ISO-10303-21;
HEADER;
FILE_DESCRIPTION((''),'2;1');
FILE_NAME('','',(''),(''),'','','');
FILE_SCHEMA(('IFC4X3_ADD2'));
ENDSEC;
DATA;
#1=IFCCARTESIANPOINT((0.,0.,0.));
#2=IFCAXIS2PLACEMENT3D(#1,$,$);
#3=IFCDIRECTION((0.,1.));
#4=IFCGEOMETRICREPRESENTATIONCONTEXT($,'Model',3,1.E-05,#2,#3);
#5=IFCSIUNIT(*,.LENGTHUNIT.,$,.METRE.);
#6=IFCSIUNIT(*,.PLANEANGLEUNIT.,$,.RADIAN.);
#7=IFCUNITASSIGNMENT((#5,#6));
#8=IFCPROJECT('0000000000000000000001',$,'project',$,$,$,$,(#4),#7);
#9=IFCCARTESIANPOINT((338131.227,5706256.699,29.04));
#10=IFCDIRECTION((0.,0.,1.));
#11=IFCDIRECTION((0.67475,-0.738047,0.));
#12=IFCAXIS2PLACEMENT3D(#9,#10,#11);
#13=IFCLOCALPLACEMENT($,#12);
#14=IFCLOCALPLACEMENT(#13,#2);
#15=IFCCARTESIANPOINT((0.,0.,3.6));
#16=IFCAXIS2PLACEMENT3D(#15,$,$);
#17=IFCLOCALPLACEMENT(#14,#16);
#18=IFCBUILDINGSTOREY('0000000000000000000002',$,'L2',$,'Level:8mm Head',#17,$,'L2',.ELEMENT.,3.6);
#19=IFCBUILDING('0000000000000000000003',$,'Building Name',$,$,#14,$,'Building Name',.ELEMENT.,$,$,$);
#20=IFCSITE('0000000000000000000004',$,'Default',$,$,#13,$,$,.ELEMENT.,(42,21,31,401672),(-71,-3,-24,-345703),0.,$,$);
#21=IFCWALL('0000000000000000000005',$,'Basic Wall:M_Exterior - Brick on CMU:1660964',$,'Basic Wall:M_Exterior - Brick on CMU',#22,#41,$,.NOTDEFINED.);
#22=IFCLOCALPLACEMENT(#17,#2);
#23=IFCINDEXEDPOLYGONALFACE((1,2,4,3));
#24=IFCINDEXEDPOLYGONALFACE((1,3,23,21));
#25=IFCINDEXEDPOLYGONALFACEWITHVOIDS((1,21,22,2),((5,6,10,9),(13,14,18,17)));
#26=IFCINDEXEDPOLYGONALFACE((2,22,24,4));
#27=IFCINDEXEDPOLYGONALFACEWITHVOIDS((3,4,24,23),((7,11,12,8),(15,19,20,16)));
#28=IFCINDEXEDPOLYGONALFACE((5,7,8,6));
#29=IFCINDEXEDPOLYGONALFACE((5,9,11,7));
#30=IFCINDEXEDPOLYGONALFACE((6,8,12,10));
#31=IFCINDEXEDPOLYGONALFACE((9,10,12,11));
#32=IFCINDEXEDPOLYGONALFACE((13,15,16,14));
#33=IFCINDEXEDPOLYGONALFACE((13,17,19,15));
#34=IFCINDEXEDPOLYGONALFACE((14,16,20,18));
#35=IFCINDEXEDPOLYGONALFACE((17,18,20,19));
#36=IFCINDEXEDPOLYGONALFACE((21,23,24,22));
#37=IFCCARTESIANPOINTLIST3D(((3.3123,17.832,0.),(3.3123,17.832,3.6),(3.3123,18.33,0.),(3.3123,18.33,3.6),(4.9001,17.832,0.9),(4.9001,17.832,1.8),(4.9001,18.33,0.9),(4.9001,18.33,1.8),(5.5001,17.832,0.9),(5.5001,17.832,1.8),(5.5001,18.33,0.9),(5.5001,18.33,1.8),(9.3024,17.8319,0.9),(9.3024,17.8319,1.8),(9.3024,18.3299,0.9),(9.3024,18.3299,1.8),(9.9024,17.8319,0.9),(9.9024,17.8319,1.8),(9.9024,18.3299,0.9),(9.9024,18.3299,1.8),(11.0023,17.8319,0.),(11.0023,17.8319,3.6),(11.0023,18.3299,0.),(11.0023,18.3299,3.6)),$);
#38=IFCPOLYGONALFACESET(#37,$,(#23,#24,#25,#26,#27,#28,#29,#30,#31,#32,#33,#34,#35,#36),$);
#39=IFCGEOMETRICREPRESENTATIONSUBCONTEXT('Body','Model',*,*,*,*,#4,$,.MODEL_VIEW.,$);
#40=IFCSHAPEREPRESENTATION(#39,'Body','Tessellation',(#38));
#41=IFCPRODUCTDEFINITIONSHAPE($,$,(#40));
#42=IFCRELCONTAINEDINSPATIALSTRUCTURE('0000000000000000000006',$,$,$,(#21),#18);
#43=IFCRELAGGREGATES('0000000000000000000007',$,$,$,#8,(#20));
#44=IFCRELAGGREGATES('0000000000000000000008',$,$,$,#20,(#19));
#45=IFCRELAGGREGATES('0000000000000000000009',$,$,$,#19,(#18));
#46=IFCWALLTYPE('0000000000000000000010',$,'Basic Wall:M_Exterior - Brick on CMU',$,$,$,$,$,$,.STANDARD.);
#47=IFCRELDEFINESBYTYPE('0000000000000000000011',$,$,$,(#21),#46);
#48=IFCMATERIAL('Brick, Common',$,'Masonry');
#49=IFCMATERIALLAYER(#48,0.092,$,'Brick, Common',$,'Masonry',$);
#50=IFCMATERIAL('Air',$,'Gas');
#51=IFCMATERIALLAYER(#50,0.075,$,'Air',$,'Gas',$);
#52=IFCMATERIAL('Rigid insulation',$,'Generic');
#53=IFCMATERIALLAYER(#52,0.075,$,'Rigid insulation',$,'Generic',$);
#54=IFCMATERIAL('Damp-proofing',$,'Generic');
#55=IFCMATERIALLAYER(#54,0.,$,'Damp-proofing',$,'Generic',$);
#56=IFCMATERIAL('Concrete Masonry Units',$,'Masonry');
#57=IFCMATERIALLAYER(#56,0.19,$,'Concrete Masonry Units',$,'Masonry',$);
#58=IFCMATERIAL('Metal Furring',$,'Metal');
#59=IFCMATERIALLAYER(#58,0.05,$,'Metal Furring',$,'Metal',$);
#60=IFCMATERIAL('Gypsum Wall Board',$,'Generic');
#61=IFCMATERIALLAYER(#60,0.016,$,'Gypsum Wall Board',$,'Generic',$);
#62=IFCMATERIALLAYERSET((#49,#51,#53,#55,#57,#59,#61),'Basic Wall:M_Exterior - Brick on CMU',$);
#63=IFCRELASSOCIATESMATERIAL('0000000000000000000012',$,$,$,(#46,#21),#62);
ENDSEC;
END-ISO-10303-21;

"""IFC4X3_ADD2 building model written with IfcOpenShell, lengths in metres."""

from ifc_helpers import new_model, si_unit, direction, frame, frame_2d, origin, place, context, subcontext, project, spatial, rectangle, extrude, material, layer, layer_set, type_object, element, save


model = new_model("IFC4X3_ADD2")

# Units and contexts
model_context = context("Model", 3, precision=1e-05, world=origin(), true_north=direction((0.0, 1.0)))
body_context = subcontext(model_context, "Body", "Model", "MODEL_VIEW")
ifc_project = project(units=[si_unit("LENGTHUNIT", "METRE"), si_unit("PLANEANGLEUNIT", "RADIAN")], contexts=[model_context])

# Site, building, storey
site_placement = place(None, frame((338131.227, 5706256.699, 29.04), z_axis=(0.0, 0.0, 1.0), x_axis=(0.67475, -0.738047, 0.0)))
site = spatial("IfcSite", under=ifc_project, at=site_placement, Name="Default", CompositionType="ELEMENT", RefLatitude=(42, 21, 31, 401672), RefLongitude=(-71, -3, -24, -345703), RefElevation=0.0)
building_placement = place(site_placement, origin())
building = spatial("IfcBuilding", under=site, at=building_placement, Name="Building Name", LongName="Building Name", CompositionType="ELEMENT")
storey_placement = place(building_placement, frame((0.0, 0.0, 3.6)))
storey = spatial("IfcBuildingStorey", under=building, at=storey_placement, Name="L2", ObjectType="Level:8mm Head", LongName="L2", CompositionType="ELEMENT", Elevation=3.6)

# Shared definitions
ifc_material_1 = material(Name="Brick, Common", Category="Masonry")
ifc_layer_1 = layer(ifc_material_1, 0.092, Name="Brick, Common", Category="Masonry")
ifc_material_2 = material(Name="Air", Category="Gas")
ifc_layer_2 = layer(ifc_material_2, 0.075, Name="Air", Category="Gas")
ifc_material_3 = material(Name="Rigid insulation", Category="Generic")
ifc_layer_3 = layer(ifc_material_3, 0.075, Name="Rigid insulation", Category="Generic")
ifc_material_4 = material(Name="Damp-proofing", Category="Generic")
ifc_layer_4 = layer(ifc_material_4, 0.0, Name="Damp-proofing", Category="Generic")
ifc_material_5 = material(Name="Concrete Masonry Units", Category="Masonry")
ifc_layer_5 = layer(ifc_material_5, 0.19, Name="Concrete Masonry Units", Category="Masonry")
ifc_material_6 = material(Name="Metal Furring", Category="Metal")
ifc_layer_6 = layer(ifc_material_6, 0.05, Name="Metal Furring", Category="Metal")
ifc_material_7 = material(Name="Gypsum Wall Board", Category="Generic")
ifc_layer_7 = layer(ifc_material_7, 0.016, Name="Gypsum Wall Board", Category="Generic")
ifc_layer_set = layer_set([ifc_layer_1, ifc_layer_2, ifc_layer_3, ifc_layer_4, ifc_layer_5, ifc_layer_6, ifc_layer_7], Name="Basic Wall:M_Exterior - Brick on CMU")
wall_type = type_object("IfcWallType", Name="Basic Wall:M_Exterior - Brick on CMU", PredefinedType="STANDARD", material=ifc_layer_set)

# Wall, openings
wall_1_placement = place(storey_placement, frame((11.0023, 18.0809, 0.0), z_axis=(0.0, 0.0, 1.0), x_axis=(-1.0, 0.000006, 0.0)))
wall_1 = element("IfcWall", 1, at=wall_1_placement, inside=storey, type_object=wall_type, material=ifc_layer_set, Name="Basic Wall:M_Exterior - Brick on CMU:1660964", ObjectType="Basic Wall:M_Exterior - Brick on CMU", PredefinedType="NOTDEFINED", context=body_context, shape_type="SweptSolid", body=[
    extrude(rectangle(XDim=7.69, YDim=0.498, at=frame_2d((3.845, 0.0), x_axis=(-1.0, 0.0))), origin(), (0.0, 0.0, 1.0), 3.6),
])
opening_1_placement = place(wall_1_placement, frame((11.0021, 18.0811, 0.9)))
element("IfcOpeningElement", 2, at=opening_1_placement, cuts=wall_1, PredefinedType="OPENING", context=body_context, shape_type="SweptSolid", body=[
    extrude(rectangle(XDim=0.9, YDim=0.6, at=frame_2d((0.0, 0.0), x_axis=(0.0, 1.0))), frame((-5.1999, -19.356, 0.45), z_axis=(0.0, 1.0, 0.0), x_axis=(1.0, 0.0, 0.0)), (0.0, 0.0, 1.0), 3.048),
])
opening_2_placement = place(wall_1_placement, frame((11.0021, 18.0811, 0.9)))
element("IfcOpeningElement", 3, at=opening_2_placement, cuts=wall_1, PredefinedType="OPENING", context=body_context, shape_type="SweptSolid", body=[
    extrude(rectangle(XDim=0.9, YDim=0.6, at=frame_2d((0.0, 0.0), x_axis=(0.0, 1.0))), frame((-9.6022, -19.356, 0.45), z_axis=(0.0, 1.0, 0.0), x_axis=(1.0, 0.0, 0.0)), (0.0, 0.0, 1.0), 3.048),
])

save(model, "model.ifc")
